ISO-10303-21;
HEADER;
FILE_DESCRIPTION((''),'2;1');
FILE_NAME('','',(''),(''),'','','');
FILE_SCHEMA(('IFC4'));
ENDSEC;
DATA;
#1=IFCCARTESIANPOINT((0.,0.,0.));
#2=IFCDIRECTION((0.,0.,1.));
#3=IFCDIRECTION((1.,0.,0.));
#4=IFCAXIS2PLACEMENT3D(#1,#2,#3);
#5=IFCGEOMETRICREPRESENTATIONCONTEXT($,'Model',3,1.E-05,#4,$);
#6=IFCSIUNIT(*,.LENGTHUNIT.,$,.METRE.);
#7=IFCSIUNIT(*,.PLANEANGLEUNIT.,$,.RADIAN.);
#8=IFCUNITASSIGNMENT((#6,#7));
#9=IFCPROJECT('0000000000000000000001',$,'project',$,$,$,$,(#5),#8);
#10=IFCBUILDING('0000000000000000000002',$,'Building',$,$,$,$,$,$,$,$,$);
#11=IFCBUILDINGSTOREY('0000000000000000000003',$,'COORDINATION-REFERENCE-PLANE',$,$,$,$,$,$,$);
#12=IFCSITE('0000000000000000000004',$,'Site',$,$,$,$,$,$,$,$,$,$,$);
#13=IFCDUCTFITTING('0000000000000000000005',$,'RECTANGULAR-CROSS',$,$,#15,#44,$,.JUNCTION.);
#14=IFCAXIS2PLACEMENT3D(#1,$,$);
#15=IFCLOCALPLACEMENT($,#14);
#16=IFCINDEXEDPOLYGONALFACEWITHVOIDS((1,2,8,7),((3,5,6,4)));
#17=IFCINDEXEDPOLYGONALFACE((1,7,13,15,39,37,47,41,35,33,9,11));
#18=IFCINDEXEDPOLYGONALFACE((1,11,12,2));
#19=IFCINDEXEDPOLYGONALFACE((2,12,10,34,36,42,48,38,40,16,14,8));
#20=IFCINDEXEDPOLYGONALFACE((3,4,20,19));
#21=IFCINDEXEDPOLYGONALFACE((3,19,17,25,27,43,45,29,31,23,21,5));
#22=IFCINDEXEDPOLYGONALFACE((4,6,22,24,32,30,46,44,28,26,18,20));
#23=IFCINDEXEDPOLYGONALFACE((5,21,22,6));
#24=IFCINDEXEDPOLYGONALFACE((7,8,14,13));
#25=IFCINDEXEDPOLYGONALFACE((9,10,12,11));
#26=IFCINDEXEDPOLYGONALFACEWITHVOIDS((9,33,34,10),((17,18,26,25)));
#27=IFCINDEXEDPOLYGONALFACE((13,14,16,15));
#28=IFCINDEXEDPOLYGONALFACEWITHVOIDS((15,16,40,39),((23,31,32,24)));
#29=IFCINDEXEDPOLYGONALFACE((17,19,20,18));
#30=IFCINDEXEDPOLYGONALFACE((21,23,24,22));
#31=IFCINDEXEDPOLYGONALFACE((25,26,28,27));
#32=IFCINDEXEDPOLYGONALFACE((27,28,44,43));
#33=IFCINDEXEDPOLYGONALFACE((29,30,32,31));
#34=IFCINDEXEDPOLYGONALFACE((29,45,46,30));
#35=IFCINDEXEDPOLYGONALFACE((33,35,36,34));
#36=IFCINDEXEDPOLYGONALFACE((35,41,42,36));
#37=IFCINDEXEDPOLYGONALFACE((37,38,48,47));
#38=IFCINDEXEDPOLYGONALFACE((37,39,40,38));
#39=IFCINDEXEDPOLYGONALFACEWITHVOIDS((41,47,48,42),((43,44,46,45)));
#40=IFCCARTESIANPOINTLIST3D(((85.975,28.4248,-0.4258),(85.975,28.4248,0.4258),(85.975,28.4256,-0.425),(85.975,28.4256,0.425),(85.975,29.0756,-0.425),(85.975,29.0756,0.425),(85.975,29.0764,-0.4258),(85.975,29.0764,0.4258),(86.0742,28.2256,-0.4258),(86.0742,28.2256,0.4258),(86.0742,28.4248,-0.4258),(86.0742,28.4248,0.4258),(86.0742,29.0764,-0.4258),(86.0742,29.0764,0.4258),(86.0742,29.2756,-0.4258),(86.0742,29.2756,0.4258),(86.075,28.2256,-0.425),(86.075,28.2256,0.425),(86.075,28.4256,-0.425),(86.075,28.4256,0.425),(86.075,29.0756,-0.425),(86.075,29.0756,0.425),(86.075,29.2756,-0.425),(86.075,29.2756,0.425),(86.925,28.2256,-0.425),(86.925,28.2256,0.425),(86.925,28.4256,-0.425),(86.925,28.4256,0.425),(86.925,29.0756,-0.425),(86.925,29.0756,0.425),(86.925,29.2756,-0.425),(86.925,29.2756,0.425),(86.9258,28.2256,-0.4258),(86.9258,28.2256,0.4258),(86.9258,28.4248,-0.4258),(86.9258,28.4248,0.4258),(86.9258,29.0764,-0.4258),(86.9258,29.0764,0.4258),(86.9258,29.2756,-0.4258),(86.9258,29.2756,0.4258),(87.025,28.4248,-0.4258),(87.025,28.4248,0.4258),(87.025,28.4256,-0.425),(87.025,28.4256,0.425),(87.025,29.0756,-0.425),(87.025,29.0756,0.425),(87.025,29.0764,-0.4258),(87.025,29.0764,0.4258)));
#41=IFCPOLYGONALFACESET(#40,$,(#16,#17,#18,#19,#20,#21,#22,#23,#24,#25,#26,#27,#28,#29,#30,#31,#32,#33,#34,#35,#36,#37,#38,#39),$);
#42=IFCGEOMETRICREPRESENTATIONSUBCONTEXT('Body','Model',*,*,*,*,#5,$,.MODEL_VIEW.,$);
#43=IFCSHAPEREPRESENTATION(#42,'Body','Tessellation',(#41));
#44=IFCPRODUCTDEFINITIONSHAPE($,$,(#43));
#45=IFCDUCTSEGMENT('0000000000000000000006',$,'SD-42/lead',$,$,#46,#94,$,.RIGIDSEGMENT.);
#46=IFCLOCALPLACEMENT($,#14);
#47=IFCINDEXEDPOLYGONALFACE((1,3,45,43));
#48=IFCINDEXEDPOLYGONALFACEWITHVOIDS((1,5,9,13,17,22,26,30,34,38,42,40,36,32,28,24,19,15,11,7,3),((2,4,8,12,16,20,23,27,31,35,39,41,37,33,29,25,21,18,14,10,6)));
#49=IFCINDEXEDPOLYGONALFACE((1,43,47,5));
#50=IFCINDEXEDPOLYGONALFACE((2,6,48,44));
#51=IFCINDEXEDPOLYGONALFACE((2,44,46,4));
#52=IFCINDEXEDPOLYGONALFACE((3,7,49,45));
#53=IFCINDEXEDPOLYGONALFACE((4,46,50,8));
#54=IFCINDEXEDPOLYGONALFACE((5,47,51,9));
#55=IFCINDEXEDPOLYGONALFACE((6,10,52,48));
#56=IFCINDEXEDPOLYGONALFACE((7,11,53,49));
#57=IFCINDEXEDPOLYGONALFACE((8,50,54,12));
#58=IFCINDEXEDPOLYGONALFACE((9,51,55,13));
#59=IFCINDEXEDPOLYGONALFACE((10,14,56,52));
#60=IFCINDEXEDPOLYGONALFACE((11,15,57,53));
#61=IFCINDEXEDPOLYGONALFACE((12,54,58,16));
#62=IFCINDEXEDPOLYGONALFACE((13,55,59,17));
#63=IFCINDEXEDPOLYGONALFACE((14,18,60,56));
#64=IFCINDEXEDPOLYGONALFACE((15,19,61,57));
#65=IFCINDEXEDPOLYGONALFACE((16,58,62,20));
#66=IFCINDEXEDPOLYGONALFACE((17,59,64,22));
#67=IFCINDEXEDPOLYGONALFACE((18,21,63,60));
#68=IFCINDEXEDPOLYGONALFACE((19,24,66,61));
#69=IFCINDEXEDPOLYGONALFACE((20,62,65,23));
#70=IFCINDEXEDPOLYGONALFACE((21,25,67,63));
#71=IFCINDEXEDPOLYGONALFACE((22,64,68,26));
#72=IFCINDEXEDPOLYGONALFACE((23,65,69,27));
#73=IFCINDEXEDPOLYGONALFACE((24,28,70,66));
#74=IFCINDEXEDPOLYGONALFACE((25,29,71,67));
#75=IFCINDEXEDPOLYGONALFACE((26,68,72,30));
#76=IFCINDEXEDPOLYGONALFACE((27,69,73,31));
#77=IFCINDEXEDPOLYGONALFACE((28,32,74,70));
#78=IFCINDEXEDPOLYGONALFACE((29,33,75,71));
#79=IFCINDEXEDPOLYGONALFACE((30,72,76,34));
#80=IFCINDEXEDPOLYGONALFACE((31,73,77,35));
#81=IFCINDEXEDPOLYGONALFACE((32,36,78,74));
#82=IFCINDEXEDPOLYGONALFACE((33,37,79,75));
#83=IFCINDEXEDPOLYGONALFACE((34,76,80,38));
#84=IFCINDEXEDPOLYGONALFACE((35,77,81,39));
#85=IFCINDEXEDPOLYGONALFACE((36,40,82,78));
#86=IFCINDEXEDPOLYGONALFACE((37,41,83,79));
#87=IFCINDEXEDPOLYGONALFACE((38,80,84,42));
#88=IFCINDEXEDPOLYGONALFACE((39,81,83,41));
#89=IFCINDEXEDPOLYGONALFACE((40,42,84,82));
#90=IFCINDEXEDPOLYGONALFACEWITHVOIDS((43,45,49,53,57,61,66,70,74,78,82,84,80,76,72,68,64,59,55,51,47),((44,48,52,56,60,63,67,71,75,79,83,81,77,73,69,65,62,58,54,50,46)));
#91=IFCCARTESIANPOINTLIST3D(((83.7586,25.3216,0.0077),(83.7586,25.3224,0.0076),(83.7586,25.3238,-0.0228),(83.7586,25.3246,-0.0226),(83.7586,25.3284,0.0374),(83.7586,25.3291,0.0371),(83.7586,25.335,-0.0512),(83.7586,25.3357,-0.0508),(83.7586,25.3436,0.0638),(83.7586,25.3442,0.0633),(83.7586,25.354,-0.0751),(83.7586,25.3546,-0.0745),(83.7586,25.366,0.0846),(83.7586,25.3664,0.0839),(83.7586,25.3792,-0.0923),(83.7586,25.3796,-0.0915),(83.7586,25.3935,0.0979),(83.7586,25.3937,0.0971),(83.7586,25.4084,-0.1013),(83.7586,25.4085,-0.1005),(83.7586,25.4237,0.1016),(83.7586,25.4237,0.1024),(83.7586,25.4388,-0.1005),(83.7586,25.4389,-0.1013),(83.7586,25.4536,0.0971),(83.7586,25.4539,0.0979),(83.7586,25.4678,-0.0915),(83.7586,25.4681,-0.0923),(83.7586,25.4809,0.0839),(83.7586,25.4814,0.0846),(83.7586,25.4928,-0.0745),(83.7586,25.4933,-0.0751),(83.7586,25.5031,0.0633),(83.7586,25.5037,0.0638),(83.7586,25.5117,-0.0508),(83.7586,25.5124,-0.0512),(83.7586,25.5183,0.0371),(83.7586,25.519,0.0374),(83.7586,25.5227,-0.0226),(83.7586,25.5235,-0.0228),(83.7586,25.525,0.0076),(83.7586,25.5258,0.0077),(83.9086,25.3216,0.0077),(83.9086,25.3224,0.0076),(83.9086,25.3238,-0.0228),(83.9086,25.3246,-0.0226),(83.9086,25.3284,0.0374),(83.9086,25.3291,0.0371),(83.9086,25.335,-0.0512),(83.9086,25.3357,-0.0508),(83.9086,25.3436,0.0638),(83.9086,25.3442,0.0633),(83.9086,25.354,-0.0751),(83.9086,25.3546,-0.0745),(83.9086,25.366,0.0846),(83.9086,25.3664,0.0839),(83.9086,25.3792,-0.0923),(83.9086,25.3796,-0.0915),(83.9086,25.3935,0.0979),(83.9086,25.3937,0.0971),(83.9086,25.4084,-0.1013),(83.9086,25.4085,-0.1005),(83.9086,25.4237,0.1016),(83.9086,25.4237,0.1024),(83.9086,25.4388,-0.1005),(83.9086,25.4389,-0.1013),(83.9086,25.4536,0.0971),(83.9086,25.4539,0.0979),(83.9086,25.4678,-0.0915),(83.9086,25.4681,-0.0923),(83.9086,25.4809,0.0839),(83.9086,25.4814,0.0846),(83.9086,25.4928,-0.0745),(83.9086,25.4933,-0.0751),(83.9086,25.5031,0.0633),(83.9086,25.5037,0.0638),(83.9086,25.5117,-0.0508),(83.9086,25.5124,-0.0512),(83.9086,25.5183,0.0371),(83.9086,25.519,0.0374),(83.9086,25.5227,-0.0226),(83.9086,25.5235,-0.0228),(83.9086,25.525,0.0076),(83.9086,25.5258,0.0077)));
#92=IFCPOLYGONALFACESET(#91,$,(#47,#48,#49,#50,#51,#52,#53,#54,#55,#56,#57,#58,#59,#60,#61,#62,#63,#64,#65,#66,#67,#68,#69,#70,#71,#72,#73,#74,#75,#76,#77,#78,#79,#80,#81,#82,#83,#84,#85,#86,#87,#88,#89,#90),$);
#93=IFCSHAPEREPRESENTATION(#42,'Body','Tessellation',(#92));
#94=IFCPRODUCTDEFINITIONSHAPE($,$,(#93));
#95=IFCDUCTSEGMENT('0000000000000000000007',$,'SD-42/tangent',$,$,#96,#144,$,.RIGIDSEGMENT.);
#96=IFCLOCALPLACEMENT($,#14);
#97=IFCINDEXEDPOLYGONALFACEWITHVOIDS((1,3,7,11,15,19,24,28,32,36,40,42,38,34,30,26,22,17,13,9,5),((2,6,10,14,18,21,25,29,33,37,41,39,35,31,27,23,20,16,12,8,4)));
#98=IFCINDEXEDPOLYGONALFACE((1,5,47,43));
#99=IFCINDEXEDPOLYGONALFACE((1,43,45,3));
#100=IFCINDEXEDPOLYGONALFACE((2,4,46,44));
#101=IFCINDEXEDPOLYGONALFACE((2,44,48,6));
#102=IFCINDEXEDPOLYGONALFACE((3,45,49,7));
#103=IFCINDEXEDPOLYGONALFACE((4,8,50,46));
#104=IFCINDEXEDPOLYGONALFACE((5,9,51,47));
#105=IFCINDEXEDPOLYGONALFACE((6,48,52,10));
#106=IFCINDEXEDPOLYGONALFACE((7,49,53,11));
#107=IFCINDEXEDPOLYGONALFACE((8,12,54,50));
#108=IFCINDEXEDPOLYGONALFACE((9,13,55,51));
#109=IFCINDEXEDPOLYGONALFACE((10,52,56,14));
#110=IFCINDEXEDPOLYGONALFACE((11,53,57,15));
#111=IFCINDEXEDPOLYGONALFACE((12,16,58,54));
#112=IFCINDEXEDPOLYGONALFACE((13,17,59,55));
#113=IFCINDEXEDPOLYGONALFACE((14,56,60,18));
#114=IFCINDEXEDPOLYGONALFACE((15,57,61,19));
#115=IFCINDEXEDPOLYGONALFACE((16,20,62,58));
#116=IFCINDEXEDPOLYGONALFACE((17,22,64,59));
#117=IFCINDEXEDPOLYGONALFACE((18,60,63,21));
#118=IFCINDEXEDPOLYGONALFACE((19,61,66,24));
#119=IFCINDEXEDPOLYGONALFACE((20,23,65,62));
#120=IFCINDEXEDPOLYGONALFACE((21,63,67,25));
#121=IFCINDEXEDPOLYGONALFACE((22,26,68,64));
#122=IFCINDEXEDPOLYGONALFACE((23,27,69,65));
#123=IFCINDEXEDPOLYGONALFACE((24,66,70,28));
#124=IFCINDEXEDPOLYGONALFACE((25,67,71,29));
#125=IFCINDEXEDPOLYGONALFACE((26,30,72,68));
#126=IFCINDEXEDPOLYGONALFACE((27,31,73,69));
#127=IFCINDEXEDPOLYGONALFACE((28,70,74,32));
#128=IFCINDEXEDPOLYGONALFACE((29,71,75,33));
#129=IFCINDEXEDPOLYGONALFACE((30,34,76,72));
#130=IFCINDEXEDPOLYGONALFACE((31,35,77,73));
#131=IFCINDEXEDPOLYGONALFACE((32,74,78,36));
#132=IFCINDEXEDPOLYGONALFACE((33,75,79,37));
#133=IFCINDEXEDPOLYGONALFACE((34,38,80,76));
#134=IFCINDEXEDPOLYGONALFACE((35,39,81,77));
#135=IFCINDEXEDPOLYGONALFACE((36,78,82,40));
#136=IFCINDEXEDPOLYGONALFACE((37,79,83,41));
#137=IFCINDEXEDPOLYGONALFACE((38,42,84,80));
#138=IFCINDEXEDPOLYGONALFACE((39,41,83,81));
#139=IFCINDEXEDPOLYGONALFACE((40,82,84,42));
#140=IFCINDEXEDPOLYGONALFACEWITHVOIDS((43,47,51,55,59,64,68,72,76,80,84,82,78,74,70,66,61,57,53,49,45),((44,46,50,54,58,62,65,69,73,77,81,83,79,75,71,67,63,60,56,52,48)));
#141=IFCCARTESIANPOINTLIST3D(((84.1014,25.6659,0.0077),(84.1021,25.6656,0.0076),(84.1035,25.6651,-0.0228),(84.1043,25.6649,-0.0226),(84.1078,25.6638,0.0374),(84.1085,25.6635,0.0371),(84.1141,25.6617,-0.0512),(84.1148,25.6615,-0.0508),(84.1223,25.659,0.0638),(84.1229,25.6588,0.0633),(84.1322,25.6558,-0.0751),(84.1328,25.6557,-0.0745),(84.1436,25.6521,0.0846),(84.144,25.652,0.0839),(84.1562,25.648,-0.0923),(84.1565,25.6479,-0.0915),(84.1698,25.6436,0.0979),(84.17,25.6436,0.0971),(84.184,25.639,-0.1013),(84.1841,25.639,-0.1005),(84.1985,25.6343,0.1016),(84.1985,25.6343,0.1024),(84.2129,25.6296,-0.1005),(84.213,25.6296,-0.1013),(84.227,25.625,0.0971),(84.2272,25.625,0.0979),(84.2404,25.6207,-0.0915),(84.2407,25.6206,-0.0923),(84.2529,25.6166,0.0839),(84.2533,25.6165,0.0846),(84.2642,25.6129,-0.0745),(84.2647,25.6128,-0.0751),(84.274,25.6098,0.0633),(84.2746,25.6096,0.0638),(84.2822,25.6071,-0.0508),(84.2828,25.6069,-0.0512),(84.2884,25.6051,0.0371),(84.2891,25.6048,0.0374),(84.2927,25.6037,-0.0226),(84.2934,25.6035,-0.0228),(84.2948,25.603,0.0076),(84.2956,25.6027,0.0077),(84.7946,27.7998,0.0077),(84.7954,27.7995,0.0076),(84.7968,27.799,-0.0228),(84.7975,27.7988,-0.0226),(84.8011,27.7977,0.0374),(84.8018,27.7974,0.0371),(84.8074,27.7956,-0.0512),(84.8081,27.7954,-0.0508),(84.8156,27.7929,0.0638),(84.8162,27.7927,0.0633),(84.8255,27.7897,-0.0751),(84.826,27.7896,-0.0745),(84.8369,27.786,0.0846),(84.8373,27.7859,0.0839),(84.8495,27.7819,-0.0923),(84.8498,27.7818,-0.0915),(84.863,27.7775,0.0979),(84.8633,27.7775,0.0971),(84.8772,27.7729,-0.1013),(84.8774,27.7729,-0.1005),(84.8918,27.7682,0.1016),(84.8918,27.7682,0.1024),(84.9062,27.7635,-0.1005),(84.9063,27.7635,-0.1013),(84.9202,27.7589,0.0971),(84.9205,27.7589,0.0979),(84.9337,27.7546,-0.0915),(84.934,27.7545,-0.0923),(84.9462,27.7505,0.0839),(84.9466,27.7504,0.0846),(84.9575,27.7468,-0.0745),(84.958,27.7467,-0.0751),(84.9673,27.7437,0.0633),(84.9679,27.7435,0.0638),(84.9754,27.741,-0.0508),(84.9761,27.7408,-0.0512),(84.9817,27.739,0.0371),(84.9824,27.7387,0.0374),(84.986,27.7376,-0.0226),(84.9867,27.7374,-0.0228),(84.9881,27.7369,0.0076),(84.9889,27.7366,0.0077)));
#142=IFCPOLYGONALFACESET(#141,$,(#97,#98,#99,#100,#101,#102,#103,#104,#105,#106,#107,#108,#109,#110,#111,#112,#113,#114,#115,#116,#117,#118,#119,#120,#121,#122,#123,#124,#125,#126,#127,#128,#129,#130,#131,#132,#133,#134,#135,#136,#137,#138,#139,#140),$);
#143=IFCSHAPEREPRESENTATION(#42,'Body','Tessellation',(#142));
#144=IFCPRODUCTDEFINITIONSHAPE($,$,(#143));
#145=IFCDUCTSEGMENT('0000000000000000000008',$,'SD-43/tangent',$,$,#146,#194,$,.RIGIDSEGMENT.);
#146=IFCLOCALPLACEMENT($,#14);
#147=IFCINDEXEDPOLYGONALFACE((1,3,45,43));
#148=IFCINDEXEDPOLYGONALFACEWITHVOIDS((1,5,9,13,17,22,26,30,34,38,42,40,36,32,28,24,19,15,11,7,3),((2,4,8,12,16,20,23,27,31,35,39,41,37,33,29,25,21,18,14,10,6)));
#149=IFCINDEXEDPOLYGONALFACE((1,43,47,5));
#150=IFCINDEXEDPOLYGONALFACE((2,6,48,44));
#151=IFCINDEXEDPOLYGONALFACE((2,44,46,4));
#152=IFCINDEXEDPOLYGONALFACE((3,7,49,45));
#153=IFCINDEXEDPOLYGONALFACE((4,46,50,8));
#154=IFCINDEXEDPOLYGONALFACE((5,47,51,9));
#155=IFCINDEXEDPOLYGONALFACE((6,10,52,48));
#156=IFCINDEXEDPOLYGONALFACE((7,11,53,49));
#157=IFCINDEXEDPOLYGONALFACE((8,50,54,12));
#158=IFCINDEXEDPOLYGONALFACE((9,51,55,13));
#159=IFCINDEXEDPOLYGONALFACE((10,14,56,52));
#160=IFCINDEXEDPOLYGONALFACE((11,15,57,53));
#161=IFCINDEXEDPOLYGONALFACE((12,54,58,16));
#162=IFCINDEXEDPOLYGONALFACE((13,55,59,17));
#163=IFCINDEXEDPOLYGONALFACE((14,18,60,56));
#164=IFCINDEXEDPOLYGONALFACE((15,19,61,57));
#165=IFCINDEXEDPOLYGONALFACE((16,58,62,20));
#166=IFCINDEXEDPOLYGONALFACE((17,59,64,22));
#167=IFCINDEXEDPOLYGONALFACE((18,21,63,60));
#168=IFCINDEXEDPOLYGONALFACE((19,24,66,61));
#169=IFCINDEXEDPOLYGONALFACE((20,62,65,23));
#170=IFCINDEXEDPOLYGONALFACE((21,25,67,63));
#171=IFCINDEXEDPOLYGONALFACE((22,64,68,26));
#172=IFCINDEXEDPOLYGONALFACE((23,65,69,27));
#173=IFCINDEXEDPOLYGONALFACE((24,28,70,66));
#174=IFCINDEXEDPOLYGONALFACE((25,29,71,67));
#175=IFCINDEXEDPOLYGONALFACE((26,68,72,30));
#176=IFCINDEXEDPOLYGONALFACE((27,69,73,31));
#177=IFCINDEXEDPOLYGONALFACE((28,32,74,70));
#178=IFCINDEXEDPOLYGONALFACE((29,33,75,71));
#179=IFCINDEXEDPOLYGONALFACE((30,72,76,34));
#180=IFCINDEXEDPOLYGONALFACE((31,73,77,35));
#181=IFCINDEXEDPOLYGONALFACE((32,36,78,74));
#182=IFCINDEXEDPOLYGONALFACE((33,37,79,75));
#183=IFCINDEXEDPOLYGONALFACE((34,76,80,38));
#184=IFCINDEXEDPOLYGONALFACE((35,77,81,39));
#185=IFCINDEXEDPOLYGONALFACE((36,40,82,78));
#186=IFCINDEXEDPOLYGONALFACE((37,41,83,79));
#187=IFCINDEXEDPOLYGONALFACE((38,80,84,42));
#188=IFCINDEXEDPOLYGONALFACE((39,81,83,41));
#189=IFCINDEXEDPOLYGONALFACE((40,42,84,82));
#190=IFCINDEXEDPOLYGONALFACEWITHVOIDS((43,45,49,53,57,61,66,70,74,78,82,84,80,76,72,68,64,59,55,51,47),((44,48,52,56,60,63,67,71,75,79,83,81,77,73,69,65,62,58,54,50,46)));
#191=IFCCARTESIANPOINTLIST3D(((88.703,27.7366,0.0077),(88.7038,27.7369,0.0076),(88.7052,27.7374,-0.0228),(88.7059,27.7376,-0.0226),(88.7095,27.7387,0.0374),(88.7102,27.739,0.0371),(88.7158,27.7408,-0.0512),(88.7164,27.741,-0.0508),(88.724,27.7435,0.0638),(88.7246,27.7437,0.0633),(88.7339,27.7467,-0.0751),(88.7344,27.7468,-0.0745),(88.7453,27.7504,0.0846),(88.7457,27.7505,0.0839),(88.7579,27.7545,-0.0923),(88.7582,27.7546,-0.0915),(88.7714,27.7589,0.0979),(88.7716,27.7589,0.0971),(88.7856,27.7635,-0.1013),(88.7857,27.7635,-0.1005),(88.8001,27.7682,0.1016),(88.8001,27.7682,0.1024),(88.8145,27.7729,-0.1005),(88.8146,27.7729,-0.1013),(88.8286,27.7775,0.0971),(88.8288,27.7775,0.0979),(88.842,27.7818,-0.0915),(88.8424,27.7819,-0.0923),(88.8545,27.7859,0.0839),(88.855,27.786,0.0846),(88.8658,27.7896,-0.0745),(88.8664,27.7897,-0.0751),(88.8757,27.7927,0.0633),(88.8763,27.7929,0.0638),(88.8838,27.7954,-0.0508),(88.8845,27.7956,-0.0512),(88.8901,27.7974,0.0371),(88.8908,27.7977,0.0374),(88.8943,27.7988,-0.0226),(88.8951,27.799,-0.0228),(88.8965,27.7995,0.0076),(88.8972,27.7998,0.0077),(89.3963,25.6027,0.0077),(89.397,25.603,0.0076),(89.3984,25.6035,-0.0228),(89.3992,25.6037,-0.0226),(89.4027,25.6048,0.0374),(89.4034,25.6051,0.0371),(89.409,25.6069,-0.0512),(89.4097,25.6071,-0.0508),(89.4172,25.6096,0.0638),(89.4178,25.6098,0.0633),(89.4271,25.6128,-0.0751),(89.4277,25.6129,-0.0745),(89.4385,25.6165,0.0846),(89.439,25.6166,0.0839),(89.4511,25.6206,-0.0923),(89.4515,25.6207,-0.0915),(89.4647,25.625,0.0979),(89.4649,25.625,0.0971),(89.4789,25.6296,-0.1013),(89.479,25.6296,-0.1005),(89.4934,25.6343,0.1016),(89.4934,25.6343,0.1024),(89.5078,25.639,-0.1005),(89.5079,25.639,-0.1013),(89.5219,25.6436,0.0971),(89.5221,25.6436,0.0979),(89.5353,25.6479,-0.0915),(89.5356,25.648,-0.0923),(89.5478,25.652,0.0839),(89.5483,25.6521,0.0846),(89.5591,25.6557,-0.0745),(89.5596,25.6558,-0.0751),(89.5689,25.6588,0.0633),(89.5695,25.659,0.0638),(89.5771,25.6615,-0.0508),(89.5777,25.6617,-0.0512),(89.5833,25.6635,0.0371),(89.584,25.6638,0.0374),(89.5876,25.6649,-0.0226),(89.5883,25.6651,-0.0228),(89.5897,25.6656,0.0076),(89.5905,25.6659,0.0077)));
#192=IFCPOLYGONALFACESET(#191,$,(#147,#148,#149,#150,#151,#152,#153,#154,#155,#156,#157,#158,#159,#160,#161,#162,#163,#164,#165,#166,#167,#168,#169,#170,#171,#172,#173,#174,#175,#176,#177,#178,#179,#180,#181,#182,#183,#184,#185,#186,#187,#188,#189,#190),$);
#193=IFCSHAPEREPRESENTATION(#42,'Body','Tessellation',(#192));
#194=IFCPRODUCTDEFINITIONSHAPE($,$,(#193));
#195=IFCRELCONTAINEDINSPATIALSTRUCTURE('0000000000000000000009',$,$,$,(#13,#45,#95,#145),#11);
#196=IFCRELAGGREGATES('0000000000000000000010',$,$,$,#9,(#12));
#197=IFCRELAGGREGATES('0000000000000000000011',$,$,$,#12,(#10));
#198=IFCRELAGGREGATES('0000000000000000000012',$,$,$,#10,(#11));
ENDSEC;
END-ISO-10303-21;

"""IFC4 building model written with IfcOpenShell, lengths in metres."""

from ifc_helpers import new_model, si_unit, frame, origin_with_axes, place, context, subcontext, project, spatial, rectangle, hollow_circle, extrude, boolean, element, save


model = new_model("IFC4")

# Units and contexts
model_context = context("Model", 3, precision=1e-05, world=origin_with_axes())
body_context = subcontext(model_context, "Body", "Model", "MODEL_VIEW")
ifc_project = project(units=[si_unit("LENGTHUNIT", "METRE"), si_unit("PLANEANGLEUNIT", "RADIAN")], contexts=[model_context])

# Site, building, storey
site = spatial("IfcSite", under=ifc_project, Name="Site")
building = spatial("IfcBuilding", under=site, Name="Building")
storey = spatial("IfcBuildingStorey", under=building, Name="COORDINATION-REFERENCE-PLANE")

# Duct fitting
duct_fitting_1_placement = place(None, frame((86.5, 28.7506, 0.0), z_axis=(0.0, -1.0, 0.0), x_axis=(1.0, 0.0, 0.0)))
solid = boolean("UNION", extrude(rectangle(XDim=0.85, YDim=0.85), frame((0.0, 0.0, -0.525), z_axis=(0.0, 0.0, 1.0), x_axis=(1.0, 0.0, 0.0)), (0.0, 0.0, 1.0), 1.05), extrude(rectangle(XDim=0.65, YDim=0.85), frame((-0.525, 0.0, 0.0), z_axis=(1.0, 0.0, 0.0), x_axis=(0.0, 0.0, -1.0)), (0.0, 0.0, 1.0), 1.05))
element("IfcDuctFitting", 1, at=duct_fitting_1_placement, inside=storey, Name="RECTANGULAR-CROSS", PredefinedType="JUNCTION", context=body_context, shape_type="CSG", body=[
    boolean("DIFFERENCE", boolean("UNION", extrude(rectangle(XDim=0.8516, YDim=0.8516), frame((0.0, 0.0, -0.525), z_axis=(0.0, 0.0, 1.0), x_axis=(1.0, 0.0, 0.0)), (0.0, 0.0, 1.0), 1.05), extrude(rectangle(XDim=0.6516, YDim=0.8516), frame((-0.525, 0.0, 0.0), z_axis=(1.0, 0.0, 0.0), x_axis=(0.0, 0.0, -1.0)), (0.0, 0.0, 1.0), 1.05)), solid),
])

# Duct segment
duct_segment_1_placement = place(None, frame((83.7586, 25.4237, 0.0), z_axis=(1.0, 0.0, 0.0), x_axis=(0.0, 0.0, 1.0)))
element("IfcDuctSegment", 2, at=duct_segment_1_placement, inside=storey, Name="SD-42/lead", PredefinedType="RIGIDSEGMENT", context=body_context, shape_type="SweptSolid", body=[
    extrude(hollow_circle(Radius=0.1024, WallThickness=0.0008), origin_with_axes(), (0.0, 0.0, 1.0), 0.15),
])

# Duct segment
duct_segment_2_placement = place(None, frame((84.1985, 25.6343, 0.0), z_axis=(0.30899, 0.951065, 0.0), x_axis=(0.0, 0.0, 1.0)))
element("IfcDuctSegment", 3, at=duct_segment_2_placement, inside=storey, Name="SD-42/tangent", PredefinedType="RIGIDSEGMENT", context=body_context, shape_type="SweptSolid", body=[
    extrude(hollow_circle(Radius=0.1024, WallThickness=0.0008), origin_with_axes(), (0.0, 0.0, 1.0), 2.2437),
])

# Duct segment
duct_segment_3_placement = place(None, frame((89.4934, 25.6343, 0.0), z_axis=(-0.30899, 0.951065, 0.0), x_axis=(0.0, 0.0, 1.0)))
element("IfcDuctSegment", 4, at=duct_segment_3_placement, inside=storey, Name="SD-43/tangent", PredefinedType="RIGIDSEGMENT", context=body_context, shape_type="SweptSolid", body=[
    extrude(hollow_circle(Radius=0.1024, WallThickness=0.0008), origin_with_axes(), (0.0, 0.0, 1.0), 2.2437),
])

save(model, "model.ifc")
